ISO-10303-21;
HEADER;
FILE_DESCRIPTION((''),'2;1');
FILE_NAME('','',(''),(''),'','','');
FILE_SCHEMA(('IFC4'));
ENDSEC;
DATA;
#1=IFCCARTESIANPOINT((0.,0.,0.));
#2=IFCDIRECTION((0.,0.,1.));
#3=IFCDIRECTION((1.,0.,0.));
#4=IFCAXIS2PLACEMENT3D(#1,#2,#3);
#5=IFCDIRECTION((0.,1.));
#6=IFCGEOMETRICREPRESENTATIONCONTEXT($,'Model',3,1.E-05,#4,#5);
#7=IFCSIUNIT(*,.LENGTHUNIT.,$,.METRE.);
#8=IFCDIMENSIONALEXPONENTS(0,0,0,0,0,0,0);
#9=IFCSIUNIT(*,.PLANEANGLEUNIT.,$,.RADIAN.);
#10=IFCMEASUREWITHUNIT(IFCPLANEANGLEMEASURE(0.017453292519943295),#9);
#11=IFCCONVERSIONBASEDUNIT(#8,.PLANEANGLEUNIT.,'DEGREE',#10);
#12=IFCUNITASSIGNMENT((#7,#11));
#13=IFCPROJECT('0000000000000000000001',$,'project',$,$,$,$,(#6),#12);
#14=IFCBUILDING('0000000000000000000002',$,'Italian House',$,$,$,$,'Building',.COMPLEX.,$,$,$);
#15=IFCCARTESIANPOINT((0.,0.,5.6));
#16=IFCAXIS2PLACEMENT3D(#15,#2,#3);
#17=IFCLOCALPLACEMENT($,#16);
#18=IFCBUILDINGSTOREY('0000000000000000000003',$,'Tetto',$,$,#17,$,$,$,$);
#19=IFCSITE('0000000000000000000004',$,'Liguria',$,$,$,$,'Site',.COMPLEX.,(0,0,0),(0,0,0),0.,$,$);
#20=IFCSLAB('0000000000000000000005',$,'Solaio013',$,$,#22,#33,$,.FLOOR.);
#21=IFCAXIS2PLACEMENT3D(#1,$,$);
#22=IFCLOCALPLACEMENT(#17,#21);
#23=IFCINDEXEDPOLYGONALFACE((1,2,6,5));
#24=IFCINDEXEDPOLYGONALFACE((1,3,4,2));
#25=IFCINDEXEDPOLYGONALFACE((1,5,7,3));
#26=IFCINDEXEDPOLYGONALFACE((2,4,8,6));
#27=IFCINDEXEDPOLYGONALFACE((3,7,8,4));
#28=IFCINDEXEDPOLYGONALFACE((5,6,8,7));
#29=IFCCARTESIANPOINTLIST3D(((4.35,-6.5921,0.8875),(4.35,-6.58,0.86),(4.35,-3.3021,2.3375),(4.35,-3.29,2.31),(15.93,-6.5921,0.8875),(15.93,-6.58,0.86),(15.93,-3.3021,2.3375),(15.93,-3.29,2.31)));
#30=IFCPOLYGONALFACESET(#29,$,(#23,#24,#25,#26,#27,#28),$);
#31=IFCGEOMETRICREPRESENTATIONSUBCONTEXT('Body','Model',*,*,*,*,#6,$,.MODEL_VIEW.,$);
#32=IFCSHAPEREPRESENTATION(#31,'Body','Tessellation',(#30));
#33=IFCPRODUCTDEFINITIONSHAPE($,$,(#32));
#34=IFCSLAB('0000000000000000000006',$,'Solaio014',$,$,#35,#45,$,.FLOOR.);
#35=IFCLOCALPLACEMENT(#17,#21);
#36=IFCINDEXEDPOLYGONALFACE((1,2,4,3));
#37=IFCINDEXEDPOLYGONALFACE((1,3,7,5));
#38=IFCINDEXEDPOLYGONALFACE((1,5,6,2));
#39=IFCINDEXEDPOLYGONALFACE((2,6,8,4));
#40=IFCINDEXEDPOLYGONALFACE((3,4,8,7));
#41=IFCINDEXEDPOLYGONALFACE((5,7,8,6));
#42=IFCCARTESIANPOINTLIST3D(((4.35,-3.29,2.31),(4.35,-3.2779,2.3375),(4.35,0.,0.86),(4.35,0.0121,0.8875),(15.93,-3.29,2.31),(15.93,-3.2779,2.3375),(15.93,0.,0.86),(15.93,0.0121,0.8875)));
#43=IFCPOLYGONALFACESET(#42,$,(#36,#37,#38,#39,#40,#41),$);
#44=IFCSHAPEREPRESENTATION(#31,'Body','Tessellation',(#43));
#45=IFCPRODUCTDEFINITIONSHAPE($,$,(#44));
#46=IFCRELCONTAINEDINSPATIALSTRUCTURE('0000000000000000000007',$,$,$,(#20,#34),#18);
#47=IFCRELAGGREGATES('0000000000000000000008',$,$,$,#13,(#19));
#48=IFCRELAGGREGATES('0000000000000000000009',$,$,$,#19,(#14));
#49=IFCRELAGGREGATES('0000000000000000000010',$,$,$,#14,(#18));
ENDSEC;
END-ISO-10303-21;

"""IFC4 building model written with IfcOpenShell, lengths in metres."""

from ifc_helpers import new_model, entity, si_unit, converted_unit, direction, frame, frame_2d, origin_with_axes, place, context, subcontext, project, spatial, rectangle, extrude, element, save


model = new_model("IFC4")

# Units and contexts
model_context = context("Model", 3, precision=1e-05, world=origin_with_axes(), true_north=direction((0.0, 1.0)))
body_context = subcontext(model_context, "Body", "Model", "MODEL_VIEW")
ifc_project = project(units=[si_unit("LENGTHUNIT", "METRE"), converted_unit("PLANEANGLEUNIT", "DEGREE", entity("IfcPlaneAngleMeasure", 0.017453292519943295), si_unit("PLANEANGLEUNIT", "RADIAN"), dimensions=[0, 0, 0, 0, 0, 0, 0])], contexts=[model_context])

# Site, building, storey
site = spatial("IfcSite", under=ifc_project, Name="Liguria", LongName="Site", CompositionType="COMPLEX", RefLatitude=(0, 0, 0), RefLongitude=(0, 0, 0), RefElevation=0.0)
building = spatial("IfcBuilding", under=site, Name="Italian House", LongName="Building", CompositionType="COMPLEX")
storey_placement = place(None, frame((0.0, 0.0, 5.6), z_axis=(0.0, 0.0, 1.0), x_axis=(1.0, 0.0, 0.0)))
storey = spatial("IfcBuildingStorey", under=building, at=storey_placement, Name="Tetto")

# Slabs
slab_1_placement = place(storey_placement, frame((0.0, 0.0, -5.6), z_axis=(0.0, 0.0, 1.0), x_axis=(1.0, 0.0, 0.0)))
element("IfcSlab", 1, at=slab_1_placement, inside=storey, Name="Solaio013", PredefinedType="FLOOR", context=body_context, shape_type="SweptSolid", body=[
    extrude(rectangle(XDim=0.03, YDim=3.5954, at=frame_2d((0.0, 0.0), x_axis=(0.915069, -0.403298))), frame((4.35, -4.941, 7.1987), z_axis=(-1.0, 0.0, 0.0), x_axis=(0.0, 0.0, 1.0)), (0.0, 0.0, -1.0), 11.58),
])
slab_2_placement = place(storey_placement, frame((0.0, 0.0, -5.6), z_axis=(0.0, 0.0, 1.0), x_axis=(1.0, 0.0, 0.0)))
element("IfcSlab", 2, at=slab_2_placement, inside=storey, Name="Solaio014", PredefinedType="FLOOR", context=body_context, shape_type="SweptSolid", body=[
    extrude(rectangle(XDim=0.03, YDim=3.5954, at=frame_2d((0.0, 0.0), x_axis=(0.915069, 0.403298))), frame((4.35, -1.639, 7.1987), z_axis=(-1.0, 0.0, 0.0), x_axis=(0.0, 0.0, 1.0)), (0.0, 0.0, -1.0), 11.58),
])

save(model, "model.ifc")
